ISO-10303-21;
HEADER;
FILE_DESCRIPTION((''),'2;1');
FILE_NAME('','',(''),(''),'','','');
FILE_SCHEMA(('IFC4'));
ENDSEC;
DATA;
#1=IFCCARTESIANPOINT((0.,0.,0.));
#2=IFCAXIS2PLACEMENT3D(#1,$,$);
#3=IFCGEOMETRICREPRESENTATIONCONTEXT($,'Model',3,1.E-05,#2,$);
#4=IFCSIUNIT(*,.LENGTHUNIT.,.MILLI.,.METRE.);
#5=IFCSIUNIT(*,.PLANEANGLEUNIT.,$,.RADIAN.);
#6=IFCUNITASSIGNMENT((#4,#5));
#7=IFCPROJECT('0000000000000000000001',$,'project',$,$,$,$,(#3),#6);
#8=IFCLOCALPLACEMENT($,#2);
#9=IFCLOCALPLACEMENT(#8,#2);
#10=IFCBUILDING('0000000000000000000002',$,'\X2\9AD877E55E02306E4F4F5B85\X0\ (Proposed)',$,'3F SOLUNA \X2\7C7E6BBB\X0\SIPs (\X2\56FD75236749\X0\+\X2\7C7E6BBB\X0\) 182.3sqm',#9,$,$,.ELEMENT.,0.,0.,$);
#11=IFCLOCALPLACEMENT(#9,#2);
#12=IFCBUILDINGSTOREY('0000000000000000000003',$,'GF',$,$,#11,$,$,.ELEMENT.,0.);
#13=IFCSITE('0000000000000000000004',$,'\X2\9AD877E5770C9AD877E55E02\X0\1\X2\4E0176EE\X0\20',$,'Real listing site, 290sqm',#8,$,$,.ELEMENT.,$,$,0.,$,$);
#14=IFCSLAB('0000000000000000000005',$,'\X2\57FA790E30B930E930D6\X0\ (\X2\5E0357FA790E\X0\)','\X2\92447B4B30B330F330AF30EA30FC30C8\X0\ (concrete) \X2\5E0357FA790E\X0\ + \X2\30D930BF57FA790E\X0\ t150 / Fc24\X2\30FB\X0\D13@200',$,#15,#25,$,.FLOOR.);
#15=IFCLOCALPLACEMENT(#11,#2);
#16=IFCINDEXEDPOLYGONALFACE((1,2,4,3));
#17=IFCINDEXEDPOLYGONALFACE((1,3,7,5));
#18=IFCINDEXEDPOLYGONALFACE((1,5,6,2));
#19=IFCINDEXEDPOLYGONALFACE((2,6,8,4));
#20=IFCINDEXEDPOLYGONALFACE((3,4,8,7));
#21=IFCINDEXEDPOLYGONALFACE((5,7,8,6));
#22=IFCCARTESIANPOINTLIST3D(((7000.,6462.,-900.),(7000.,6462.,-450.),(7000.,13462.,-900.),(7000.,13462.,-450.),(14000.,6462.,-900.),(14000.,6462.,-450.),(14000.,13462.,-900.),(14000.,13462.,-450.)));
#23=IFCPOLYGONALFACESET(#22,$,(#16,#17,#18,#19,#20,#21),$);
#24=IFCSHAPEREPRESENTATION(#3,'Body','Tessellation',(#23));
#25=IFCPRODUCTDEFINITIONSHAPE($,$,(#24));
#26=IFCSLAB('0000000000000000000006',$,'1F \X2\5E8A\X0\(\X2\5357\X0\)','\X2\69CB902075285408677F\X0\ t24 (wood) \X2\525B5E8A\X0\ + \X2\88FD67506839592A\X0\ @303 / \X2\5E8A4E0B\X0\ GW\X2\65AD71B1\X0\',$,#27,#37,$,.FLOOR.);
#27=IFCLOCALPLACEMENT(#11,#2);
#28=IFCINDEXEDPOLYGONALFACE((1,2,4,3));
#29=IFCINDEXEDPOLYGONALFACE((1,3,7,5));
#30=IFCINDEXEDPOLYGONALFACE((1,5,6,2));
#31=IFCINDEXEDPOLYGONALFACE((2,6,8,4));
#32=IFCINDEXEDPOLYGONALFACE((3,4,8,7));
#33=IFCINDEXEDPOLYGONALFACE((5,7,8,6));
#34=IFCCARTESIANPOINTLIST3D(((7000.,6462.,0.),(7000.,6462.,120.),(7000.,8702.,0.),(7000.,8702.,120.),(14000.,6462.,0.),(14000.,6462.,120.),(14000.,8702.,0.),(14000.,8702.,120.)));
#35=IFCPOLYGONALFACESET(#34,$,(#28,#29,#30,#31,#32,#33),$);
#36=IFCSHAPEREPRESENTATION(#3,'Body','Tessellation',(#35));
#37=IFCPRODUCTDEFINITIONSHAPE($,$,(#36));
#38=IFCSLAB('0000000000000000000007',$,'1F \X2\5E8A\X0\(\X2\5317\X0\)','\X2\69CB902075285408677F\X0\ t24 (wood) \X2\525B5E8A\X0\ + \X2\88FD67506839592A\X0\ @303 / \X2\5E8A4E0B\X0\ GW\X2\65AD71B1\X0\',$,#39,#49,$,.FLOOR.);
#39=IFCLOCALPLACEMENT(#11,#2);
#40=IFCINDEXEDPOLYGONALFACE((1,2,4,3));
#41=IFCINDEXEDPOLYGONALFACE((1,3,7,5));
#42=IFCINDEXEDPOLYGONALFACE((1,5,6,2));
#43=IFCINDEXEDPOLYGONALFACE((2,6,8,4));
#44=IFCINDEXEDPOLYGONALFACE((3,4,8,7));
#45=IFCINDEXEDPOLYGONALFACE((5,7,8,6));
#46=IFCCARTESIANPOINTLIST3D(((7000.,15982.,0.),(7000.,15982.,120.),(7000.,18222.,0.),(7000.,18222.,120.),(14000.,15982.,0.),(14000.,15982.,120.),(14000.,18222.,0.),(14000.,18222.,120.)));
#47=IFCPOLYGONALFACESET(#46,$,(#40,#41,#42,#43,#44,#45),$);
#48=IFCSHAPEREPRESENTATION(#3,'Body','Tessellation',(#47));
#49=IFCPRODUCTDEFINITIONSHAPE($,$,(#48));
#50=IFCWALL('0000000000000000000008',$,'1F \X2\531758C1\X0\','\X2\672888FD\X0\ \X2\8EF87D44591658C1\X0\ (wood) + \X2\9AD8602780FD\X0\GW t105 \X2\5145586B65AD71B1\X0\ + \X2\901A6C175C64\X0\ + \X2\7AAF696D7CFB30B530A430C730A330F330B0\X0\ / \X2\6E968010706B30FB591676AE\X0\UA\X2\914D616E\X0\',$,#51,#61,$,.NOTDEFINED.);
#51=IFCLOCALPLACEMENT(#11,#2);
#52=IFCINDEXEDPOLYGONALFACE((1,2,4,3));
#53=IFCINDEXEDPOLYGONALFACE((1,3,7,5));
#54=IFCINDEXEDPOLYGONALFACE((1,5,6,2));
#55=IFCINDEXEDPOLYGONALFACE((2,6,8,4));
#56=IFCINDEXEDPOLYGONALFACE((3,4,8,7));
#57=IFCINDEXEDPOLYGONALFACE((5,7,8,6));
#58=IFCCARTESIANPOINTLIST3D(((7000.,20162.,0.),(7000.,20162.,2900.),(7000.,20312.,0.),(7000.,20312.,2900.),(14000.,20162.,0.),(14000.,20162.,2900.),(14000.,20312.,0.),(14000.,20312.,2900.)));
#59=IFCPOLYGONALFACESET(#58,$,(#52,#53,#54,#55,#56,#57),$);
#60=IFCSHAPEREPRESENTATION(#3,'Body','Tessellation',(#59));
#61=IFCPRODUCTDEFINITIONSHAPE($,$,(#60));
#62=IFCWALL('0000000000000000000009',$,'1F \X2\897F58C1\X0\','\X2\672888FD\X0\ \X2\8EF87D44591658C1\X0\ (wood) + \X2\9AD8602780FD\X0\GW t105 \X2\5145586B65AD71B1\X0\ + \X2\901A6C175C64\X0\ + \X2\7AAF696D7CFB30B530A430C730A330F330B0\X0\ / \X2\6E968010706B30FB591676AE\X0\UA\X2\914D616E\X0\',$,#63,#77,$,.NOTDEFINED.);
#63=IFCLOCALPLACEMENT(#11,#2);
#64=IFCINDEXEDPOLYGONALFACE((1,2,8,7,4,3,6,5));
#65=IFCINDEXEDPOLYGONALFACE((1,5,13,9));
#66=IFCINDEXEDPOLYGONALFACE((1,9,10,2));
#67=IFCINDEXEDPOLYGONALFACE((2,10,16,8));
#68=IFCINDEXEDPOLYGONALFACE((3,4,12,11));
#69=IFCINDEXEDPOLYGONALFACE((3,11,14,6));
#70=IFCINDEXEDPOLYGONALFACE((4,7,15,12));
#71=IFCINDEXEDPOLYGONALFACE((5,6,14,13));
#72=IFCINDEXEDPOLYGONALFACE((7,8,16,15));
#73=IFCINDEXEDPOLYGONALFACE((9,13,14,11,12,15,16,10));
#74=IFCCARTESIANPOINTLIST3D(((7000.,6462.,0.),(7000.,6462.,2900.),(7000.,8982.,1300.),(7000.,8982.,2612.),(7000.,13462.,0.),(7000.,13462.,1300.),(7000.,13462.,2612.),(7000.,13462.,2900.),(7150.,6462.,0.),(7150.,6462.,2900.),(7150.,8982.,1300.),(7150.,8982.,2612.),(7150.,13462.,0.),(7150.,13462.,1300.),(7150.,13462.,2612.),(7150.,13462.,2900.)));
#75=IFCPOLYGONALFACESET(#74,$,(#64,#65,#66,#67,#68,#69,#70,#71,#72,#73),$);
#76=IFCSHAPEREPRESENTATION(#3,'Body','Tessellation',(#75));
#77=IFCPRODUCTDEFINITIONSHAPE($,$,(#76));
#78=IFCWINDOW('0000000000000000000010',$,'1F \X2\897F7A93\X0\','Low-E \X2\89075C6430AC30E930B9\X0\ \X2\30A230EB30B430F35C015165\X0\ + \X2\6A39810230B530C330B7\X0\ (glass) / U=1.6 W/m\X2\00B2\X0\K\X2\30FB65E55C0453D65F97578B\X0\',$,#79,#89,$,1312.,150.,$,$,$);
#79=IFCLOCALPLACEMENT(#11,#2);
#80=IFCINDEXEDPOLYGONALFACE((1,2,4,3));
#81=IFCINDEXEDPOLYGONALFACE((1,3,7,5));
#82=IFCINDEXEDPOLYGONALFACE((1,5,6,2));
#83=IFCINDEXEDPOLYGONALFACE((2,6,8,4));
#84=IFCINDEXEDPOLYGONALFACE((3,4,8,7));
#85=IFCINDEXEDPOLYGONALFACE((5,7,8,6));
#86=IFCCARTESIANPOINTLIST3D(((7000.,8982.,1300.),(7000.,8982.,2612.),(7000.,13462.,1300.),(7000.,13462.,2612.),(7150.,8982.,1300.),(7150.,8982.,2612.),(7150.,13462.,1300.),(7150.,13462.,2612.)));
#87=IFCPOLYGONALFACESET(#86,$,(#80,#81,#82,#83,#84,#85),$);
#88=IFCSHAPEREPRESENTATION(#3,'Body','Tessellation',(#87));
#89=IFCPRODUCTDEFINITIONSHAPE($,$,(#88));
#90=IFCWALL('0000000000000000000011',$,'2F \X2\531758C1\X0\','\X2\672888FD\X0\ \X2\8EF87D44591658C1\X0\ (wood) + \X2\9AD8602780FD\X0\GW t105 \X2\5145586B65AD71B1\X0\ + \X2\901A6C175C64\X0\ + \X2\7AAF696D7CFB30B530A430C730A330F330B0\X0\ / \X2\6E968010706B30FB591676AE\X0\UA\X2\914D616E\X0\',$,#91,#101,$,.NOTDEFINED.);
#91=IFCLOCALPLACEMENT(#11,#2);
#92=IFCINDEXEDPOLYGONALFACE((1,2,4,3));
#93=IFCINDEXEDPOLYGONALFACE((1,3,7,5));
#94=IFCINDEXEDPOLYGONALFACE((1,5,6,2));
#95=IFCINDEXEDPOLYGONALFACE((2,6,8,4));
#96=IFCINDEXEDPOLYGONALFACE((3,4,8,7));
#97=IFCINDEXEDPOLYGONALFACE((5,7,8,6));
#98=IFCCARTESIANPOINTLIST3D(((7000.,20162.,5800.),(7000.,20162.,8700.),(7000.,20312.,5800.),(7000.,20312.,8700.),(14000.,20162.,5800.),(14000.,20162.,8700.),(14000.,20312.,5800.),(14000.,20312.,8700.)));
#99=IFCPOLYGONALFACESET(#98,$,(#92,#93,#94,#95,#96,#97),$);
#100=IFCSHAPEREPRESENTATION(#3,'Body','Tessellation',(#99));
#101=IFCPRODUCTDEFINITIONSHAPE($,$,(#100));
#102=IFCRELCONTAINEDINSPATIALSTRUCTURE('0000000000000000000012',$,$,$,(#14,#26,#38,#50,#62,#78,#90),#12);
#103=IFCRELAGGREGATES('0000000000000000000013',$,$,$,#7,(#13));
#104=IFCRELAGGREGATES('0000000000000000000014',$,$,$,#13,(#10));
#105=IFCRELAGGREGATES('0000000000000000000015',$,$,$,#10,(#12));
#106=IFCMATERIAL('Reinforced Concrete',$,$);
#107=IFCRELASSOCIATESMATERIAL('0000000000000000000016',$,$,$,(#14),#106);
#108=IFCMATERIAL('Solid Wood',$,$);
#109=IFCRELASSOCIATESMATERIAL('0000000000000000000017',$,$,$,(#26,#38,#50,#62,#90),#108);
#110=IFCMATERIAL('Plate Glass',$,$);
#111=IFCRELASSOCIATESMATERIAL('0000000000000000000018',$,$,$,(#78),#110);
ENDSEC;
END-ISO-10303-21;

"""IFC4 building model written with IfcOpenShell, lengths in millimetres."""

from ifc_helpers import new_model, si_unit, frame, frame_2d, origin, place, context, project, spatial, rectangle, extrude, material, element, fill, save


model = new_model("IFC4")

# Units and contexts
model_context = context("Model", 3, precision=1e-05, world=origin())
ifc_project = project(units=[si_unit("LENGTHUNIT", "METRE", prefix="MILLI"), si_unit("PLANEANGLEUNIT", "RADIAN")], contexts=[model_context])

# Site, building, storey
site_placement = place(None, origin())
site = spatial("IfcSite", under=ifc_project, at=site_placement, Name="高知県高知市1丁目20", ObjectType="Real listing site, 290sqm", CompositionType="ELEMENT", RefElevation=0.0)
building_placement = place(site_placement, origin())
building = spatial("IfcBuilding", under=site, at=building_placement, Name="高知市の住宅 (Proposed)", ObjectType="3F SOLUNA 籾殻SIPs (国産杉+籾殻) 182.3sqm", CompositionType="ELEMENT", ElevationOfRefHeight=0.0, ElevationOfTerrain=0.0)
storey_placement = place(building_placement, origin())
storey = spatial("IfcBuildingStorey", under=building, at=storey_placement, Name="GF", CompositionType="ELEMENT", Elevation=0.0)

# Slabs
ifc_material_1 = material(Name="Reinforced Concrete")
slab_1_placement = place(storey_placement, frame((3500.0, 3231.0, -450.0)))
element("IfcSlab", 1, at=slab_1_placement, inside=storey, material=ifc_material_1, Name="基礎スラブ (布基礎)", Description="鉄筋コンクリート (concrete) 布基礎 + ベタ基礎 t150 / Fc24・D13@200", PredefinedType="FLOOR", context=model_context, shape_type="SweptSolid", body=[
    extrude(rectangle(XDim=7000.0, YDim=7000.0, at=frame_2d((3500.0, 3500.0))), frame((3500.0, 3231.0, -450.0)), (0.0, 0.0, 1.0), 450.0),
])
ifc_material_2 = material(Name="Solid Wood")
slab_2_placement = place(storey_placement, frame((3500.0, 3231.0, 0.0)))
element("IfcSlab", 2, at=slab_2_placement, inside=storey, material=ifc_material_2, Name="1F 床(南)", Description="構造用合板 t24 (wood) 剛床 + 製材根太 @303 / 床下 GW断熱", PredefinedType="FLOOR", context=model_context, shape_type="SweptSolid", body=[
    extrude(rectangle(XDim=7000.0, YDim=2240.0, at=frame_2d((3500.0, 1120.0))), frame((3500.0, 3231.0, 0.0)), (0.0, 0.0, 1.0), 120.0),
])
slab_3_placement = place(storey_placement, frame((3500.0, 7991.0, 0.0)))
element("IfcSlab", 3, at=slab_3_placement, inside=storey, material=ifc_material_2, Name="1F 床(北)", Description="構造用合板 t24 (wood) 剛床 + 製材根太 @303 / 床下 GW断熱", PredefinedType="FLOOR", context=model_context, shape_type="SweptSolid", body=[
    extrude(rectangle(XDim=7000.0, YDim=2240.0, at=frame_2d((3500.0, 1120.0))), frame((3500.0, 7991.0, 0.0)), (0.0, 0.0, 1.0), 120.0),
])

# Shared definitions
ifc_material_3 = material(Name="Plate Glass")

# Wall
wall_1_placement = place(storey_placement, frame((3500.0, 10081.0, 0.0)))
element("IfcWall", 4, at=wall_1_placement, inside=storey, material=ifc_material_2, Name="1F 北壁", Description="木製 軸組外壁 (wood) + 高性能GW t105 充填断熱 + 通気層 + 窯業系サイディング / 準耐火・外皮UA配慮", PredefinedType="NOTDEFINED", context=model_context, shape_type="SweptSolid", body=[
    extrude(rectangle(XDim=7000.0, YDim=150.0, at=frame_2d((3500.0, 75.0))), frame((3500.0, 10081.0, 0.0)), (0.0, 0.0, 1.0), 2900.0),
])

# Wall, opening, window
wall_2_placement = place(storey_placement, frame((3500.0, 3231.0, 0.0)))
wall_2 = element("IfcWall", 5, at=wall_2_placement, inside=storey, material=ifc_material_2, Name="1F 西壁", Description="木製 軸組外壁 (wood) + 高性能GW t105 充填断熱 + 通気層 + 窯業系サイディング / 準耐火・外皮UA配慮", PredefinedType="NOTDEFINED", context=model_context, shape_type="SweptSolid", body=[
    extrude(rectangle(XDim=150.0, YDim=7000.0, at=frame_2d((75.0, 3500.0))), frame((3500.0, 3231.0, 0.0)), (0.0, 0.0, 1.0), 2900.0),
])
opening_1_placement = place(storey_placement, frame((3500.0, 4491.0, 650.0)))
opening_1 = element("IfcOpeningElement", 6, at=opening_1_placement, cuts=wall_2, PredefinedType="NOTDEFINED", context=model_context, shape_type="SweptSolid", body=[
    extrude(rectangle(XDim=150.0, YDim=4480.0, at=frame_2d((75.0, 2240.0))), frame((3500.0, 4491.0, 650.0)), (0.0, 0.0, 1.0), 1312.0),
])
window_1_placement = place(storey_placement, frame((3500.0, 4491.0, 650.0)))
window_1 = element("IfcWindow", 7, at=window_1_placement, inside=storey, material=ifc_material_3, Name="1F 西窓", Description="Low-E 複層ガラス アルゴン封入 + 樹脂サッシ (glass) / U=1.6 W/m²K・日射取得型", OverallHeight=1312.0, OverallWidth=150.0, context=model_context, shape_type="SweptSolid", body=[
    extrude(rectangle(XDim=150.0, YDim=4480.0, at=frame_2d((75.0, 2240.0))), frame((3500.0, 4491.0, 650.0)), (0.0, 0.0, 1.0), 1312.0),
])
fill(opening_1, window_1)

# Wall
wall_3_placement = place(storey_placement, frame((3500.0, 10081.0, 2900.0)))
element("IfcWall", 8, at=wall_3_placement, inside=storey, material=ifc_material_2, Name="2F 北壁", Description="木製 軸組外壁 (wood) + 高性能GW t105 充填断熱 + 通気層 + 窯業系サイディング / 準耐火・外皮UA配慮", PredefinedType="NOTDEFINED", context=model_context, shape_type="SweptSolid", body=[
    extrude(rectangle(XDim=7000.0, YDim=150.0, at=frame_2d((3500.0, 75.0))), frame((3500.0, 10081.0, 2900.0)), (0.0, 0.0, 1.0), 2900.0),
])

save(model, "model.ifc")
